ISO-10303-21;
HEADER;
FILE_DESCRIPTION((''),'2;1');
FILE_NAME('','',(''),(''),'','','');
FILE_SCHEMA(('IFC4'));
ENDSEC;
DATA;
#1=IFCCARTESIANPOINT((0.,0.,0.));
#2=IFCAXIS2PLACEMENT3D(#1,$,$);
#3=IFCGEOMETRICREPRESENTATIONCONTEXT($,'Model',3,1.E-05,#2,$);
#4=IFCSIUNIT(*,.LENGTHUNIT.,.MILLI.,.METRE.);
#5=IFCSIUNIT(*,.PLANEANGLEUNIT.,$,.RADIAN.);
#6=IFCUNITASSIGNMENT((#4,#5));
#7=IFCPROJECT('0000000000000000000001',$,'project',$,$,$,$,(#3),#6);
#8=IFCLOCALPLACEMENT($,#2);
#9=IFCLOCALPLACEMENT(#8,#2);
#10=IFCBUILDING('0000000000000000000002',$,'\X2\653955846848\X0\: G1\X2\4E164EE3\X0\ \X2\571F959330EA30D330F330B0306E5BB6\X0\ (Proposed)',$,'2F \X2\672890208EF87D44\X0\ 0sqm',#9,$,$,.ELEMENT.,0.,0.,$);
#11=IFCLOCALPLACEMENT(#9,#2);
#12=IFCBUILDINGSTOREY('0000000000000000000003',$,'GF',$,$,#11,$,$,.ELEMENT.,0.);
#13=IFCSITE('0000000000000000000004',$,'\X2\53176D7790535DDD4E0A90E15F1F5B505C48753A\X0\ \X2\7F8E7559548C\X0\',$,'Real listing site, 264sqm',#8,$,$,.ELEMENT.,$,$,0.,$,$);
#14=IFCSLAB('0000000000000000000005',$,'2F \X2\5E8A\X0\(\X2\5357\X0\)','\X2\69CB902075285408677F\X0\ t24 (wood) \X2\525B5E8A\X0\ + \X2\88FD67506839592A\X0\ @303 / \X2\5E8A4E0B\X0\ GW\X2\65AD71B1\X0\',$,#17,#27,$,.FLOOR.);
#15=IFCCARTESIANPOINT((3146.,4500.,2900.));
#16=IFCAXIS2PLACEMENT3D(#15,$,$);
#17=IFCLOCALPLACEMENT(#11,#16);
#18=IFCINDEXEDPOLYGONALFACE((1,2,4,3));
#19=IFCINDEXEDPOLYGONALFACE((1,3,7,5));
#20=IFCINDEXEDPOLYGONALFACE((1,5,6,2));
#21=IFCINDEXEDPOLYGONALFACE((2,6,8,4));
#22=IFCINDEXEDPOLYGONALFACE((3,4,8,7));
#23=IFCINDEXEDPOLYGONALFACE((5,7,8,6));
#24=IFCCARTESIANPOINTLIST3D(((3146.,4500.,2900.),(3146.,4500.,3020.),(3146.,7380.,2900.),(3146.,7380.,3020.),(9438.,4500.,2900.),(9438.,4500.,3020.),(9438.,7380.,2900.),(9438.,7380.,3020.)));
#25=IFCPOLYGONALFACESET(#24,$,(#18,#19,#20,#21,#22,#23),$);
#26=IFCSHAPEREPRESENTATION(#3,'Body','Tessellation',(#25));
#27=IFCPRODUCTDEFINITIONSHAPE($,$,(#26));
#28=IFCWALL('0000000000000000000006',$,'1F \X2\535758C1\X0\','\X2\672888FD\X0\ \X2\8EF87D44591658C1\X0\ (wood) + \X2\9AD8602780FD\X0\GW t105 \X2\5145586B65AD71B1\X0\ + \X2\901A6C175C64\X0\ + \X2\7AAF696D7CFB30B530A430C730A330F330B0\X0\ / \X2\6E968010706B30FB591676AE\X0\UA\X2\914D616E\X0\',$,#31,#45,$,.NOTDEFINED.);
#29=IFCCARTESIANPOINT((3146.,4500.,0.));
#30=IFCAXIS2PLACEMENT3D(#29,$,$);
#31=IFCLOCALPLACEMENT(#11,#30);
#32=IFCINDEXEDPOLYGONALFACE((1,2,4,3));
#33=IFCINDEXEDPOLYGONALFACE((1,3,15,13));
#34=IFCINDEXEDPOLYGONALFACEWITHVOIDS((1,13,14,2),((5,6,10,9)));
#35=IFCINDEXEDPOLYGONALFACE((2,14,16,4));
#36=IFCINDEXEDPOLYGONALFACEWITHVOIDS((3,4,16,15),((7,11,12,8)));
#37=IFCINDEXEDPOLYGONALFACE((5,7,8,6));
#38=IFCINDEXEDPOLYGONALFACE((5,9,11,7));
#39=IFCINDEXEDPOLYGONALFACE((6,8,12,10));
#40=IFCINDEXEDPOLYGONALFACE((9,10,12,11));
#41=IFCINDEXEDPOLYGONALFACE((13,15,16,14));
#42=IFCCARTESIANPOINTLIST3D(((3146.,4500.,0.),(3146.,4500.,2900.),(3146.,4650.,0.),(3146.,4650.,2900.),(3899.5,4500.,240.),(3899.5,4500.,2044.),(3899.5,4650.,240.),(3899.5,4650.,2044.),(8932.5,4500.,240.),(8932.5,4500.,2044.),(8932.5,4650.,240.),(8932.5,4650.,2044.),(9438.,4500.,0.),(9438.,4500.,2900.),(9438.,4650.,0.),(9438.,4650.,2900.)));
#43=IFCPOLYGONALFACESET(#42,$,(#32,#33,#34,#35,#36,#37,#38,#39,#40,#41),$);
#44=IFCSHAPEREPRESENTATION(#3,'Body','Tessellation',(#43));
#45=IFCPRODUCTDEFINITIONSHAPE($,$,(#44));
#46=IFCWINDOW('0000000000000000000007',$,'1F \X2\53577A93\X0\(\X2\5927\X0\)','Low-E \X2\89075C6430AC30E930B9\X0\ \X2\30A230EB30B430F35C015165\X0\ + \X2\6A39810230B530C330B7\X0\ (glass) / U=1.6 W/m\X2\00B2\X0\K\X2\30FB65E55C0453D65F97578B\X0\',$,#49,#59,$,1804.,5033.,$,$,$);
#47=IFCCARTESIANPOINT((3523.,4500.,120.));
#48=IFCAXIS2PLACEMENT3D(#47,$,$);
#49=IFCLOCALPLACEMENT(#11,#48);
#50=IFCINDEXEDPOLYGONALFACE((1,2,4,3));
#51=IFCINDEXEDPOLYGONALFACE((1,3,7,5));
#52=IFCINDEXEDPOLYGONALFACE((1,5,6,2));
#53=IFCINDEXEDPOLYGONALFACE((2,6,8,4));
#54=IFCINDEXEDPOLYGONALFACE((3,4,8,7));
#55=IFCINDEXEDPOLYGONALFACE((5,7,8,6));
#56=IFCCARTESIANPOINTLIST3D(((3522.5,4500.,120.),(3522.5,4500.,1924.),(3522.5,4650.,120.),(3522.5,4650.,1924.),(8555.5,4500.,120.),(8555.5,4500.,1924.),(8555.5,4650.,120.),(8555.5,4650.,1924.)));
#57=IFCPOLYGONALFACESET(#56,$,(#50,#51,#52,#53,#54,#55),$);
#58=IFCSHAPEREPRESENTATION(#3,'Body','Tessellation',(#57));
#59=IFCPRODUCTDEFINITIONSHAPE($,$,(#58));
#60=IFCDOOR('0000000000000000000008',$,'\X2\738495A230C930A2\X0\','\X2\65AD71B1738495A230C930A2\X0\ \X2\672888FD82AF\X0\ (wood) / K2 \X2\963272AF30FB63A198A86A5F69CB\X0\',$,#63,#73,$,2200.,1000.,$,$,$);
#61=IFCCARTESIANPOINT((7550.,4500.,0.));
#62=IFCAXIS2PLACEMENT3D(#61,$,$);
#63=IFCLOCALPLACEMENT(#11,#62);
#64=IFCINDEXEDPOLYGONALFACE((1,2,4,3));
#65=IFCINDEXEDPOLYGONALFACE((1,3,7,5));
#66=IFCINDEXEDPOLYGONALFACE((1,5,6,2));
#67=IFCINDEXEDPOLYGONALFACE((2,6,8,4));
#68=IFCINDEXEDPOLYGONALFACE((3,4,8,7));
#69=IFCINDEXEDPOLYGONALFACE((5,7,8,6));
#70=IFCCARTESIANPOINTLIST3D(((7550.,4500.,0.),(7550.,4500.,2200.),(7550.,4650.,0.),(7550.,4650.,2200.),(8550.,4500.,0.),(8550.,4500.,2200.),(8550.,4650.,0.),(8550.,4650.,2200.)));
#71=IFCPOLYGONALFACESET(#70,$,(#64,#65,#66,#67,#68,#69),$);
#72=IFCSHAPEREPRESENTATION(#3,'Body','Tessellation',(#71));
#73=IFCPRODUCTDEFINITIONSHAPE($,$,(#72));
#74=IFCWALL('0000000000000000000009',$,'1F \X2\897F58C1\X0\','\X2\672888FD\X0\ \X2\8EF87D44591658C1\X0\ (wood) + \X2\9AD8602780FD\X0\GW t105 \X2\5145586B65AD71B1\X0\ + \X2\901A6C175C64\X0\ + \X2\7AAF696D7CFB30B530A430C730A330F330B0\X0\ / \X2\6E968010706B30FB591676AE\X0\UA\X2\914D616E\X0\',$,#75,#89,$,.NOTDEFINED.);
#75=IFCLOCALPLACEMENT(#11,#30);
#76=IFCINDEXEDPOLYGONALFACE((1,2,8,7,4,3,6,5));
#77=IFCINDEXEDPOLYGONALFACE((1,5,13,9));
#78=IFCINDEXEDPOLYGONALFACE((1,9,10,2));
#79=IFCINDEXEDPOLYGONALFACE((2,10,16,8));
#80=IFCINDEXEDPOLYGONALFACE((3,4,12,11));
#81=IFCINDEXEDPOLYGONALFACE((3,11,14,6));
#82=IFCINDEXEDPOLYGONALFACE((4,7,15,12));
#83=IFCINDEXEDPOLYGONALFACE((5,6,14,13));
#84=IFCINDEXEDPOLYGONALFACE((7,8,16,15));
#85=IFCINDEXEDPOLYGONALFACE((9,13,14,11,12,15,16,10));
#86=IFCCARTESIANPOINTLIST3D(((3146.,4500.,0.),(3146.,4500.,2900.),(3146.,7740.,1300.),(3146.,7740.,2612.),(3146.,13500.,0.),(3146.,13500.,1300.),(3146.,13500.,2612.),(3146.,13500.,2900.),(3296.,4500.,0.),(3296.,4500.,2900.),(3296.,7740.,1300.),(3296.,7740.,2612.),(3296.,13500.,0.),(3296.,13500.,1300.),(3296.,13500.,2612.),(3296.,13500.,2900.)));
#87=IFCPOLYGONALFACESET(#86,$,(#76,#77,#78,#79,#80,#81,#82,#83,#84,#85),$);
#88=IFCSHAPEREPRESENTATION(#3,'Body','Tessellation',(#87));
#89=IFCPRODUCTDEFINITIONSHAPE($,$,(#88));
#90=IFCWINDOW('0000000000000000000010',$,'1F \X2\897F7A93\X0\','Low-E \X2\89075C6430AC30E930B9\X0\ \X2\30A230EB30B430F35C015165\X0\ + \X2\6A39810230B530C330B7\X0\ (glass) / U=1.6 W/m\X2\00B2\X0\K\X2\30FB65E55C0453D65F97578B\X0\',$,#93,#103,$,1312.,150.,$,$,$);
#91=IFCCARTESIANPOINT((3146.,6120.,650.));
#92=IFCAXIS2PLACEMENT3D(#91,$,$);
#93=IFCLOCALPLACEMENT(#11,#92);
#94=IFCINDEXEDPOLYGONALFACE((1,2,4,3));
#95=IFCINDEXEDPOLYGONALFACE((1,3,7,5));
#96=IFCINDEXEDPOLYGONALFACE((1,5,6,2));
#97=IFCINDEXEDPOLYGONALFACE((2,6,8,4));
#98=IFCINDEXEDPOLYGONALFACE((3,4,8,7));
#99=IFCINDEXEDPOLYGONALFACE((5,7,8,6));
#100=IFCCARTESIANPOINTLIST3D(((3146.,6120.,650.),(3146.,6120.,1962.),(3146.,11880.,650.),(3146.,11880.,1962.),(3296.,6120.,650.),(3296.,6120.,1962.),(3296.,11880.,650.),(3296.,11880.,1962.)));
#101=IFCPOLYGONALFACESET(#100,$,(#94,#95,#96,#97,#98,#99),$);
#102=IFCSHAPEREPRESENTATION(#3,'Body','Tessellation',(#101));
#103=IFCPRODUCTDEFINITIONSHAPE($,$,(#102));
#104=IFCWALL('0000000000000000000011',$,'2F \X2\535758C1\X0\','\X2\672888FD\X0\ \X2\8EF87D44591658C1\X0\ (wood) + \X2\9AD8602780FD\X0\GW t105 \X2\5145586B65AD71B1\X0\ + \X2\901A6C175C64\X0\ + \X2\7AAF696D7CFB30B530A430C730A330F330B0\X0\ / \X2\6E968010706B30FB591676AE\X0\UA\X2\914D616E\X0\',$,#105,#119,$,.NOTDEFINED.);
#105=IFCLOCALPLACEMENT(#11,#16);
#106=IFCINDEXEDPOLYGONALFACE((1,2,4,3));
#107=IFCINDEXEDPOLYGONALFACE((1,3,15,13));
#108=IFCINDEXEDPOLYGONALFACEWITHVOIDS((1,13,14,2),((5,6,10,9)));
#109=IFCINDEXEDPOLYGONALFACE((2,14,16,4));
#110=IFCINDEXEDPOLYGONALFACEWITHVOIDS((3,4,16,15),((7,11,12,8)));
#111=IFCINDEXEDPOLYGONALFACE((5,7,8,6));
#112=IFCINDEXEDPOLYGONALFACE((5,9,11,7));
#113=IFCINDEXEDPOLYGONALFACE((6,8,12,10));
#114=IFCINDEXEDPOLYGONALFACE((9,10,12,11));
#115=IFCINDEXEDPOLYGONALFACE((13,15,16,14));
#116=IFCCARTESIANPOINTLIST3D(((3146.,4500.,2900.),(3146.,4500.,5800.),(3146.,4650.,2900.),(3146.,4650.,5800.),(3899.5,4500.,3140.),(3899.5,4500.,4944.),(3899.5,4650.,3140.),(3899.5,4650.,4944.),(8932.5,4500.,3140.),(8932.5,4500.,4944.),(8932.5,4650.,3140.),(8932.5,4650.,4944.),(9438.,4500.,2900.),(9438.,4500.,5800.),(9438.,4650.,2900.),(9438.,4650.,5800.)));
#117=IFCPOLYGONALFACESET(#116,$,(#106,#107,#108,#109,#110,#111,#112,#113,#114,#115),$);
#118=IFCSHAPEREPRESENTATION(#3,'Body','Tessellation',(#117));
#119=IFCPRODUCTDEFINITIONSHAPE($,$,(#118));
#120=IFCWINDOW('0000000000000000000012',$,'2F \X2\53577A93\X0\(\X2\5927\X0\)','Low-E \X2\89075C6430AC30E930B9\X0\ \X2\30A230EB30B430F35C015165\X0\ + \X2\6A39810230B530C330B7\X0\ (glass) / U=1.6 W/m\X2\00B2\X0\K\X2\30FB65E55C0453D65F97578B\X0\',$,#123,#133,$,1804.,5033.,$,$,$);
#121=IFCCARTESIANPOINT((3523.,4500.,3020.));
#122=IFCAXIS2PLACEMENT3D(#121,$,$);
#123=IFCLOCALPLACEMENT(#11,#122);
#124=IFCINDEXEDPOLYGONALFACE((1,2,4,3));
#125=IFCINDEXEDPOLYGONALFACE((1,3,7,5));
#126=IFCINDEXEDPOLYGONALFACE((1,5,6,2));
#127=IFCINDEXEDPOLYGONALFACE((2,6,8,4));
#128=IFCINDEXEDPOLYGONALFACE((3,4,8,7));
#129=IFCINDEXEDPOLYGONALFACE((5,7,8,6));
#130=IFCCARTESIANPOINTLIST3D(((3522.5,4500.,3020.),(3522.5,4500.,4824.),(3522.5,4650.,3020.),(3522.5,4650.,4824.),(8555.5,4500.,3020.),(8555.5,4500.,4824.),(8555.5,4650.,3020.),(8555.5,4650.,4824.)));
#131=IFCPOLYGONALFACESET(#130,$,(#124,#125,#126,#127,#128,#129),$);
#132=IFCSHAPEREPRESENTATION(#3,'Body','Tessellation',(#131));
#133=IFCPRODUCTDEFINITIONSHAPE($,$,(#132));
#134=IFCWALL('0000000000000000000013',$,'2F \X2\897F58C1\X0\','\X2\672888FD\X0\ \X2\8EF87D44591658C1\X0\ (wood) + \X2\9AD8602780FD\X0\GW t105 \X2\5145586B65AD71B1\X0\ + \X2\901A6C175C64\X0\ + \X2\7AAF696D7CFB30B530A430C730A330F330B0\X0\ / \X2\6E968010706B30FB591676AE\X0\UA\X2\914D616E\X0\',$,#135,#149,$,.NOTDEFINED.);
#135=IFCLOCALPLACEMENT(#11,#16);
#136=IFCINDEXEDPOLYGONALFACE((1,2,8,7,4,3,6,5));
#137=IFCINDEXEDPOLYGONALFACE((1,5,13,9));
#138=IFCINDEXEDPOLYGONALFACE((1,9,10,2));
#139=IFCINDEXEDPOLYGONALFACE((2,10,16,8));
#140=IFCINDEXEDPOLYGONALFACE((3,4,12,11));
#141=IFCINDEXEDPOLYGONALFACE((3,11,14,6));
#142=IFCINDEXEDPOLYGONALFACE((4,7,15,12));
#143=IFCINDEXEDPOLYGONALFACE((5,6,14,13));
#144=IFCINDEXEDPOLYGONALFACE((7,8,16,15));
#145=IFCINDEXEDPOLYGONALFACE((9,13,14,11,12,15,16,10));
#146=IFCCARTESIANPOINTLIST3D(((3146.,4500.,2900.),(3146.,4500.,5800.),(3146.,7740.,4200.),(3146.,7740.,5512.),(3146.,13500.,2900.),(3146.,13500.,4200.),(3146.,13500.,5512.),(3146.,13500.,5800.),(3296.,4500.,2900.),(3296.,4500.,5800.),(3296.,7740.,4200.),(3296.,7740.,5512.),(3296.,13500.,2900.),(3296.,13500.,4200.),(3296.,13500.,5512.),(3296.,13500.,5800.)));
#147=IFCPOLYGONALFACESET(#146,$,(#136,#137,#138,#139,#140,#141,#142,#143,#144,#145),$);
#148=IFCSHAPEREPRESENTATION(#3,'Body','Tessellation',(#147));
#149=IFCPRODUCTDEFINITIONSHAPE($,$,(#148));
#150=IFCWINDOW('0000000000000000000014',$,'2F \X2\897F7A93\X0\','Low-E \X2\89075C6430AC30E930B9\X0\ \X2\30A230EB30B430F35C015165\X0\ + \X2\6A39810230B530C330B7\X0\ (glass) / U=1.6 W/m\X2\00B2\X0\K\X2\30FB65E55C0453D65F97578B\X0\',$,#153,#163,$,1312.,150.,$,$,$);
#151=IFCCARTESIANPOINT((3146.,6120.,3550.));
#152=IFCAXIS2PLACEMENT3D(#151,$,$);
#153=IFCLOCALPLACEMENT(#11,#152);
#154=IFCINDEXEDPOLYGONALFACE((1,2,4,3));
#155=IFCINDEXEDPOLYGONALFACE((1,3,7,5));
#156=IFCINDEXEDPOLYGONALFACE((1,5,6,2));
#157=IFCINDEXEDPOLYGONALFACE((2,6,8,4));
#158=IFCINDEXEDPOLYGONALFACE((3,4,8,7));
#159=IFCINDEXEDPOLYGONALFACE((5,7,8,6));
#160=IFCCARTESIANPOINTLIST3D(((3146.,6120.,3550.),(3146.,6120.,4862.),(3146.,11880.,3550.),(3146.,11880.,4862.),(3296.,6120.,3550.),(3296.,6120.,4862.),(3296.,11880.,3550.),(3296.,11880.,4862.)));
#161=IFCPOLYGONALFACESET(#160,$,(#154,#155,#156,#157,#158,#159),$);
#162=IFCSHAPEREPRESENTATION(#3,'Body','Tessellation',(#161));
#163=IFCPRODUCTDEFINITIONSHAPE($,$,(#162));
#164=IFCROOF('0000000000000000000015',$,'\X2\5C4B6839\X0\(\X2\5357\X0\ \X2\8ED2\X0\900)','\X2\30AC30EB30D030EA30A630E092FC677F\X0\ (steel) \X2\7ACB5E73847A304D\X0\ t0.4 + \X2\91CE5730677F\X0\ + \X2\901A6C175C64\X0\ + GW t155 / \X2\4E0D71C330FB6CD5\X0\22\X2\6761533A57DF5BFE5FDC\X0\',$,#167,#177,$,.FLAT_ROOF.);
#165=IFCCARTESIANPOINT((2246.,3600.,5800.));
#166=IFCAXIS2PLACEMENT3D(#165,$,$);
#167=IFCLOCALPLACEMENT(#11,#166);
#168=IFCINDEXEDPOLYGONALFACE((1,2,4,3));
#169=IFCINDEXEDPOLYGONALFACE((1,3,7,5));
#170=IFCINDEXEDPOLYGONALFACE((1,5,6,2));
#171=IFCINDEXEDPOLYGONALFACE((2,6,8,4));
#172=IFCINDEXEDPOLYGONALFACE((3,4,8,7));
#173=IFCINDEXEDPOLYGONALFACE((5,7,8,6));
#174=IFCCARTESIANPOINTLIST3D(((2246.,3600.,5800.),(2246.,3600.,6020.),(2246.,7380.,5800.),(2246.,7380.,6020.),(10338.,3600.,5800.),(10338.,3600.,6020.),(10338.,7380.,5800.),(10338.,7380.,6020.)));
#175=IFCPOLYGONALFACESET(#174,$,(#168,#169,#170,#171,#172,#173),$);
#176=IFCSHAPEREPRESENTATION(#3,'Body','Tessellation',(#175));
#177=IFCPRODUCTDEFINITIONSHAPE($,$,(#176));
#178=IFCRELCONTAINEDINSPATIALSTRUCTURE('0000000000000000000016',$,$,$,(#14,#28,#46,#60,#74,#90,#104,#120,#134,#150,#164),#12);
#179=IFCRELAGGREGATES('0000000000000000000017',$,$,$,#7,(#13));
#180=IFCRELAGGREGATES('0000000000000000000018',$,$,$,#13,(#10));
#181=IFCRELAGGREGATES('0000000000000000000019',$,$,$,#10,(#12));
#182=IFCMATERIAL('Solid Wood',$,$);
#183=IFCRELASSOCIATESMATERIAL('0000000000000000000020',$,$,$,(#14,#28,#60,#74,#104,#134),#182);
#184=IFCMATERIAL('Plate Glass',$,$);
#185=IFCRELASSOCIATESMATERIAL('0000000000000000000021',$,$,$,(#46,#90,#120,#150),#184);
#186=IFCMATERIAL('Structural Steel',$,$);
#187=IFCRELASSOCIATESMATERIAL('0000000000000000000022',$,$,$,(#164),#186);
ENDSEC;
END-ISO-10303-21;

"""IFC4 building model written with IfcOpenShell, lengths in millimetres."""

from ifc_helpers import new_model, si_unit, frame, frame_2d, origin, place, context, project, spatial, rectangle, extrude, material, element, fill, save


model = new_model("IFC4")

# Units and contexts
model_context = context("Model", 3, precision=1e-05, world=origin())
ifc_project = project(units=[si_unit("LENGTHUNIT", "METRE", prefix="MILLI"), si_unit("PLANEANGLEUNIT", "RADIAN")], contexts=[model_context])

# Site, building, storey
site_placement = place(None, origin())
site = spatial("IfcSite", under=ifc_project, at=site_placement, Name="北海道川上郡弟子屈町 美留和", ObjectType="Real listing site, 264sqm", CompositionType="ELEMENT", RefElevation=0.0)
building_placement = place(site_placement, origin())
building = spatial("IfcBuilding", under=site, at=building_placement, Name="改善案: G1世代 土間リビングの家 (Proposed)", ObjectType="2F 木造軸組 0sqm", CompositionType="ELEMENT", ElevationOfRefHeight=0.0, ElevationOfTerrain=0.0)
storey_placement = place(building_placement, origin())
storey = spatial("IfcBuildingStorey", under=building, at=storey_placement, Name="GF", CompositionType="ELEMENT", Elevation=0.0)

# Slab
ifc_material_1 = material(Name="Solid Wood")
slab_1_placement = place(storey_placement, frame((3146.0, 4500.0, 2900.0)))
element("IfcSlab", 1, at=slab_1_placement, inside=storey, material=ifc_material_1, Name="2F 床(南)", Description="構造用合板 t24 (wood) 剛床 + 製材根太 @303 / 床下 GW断熱", PredefinedType="FLOOR", context=model_context, shape_type="SweptSolid", body=[
    extrude(rectangle(XDim=6292.0, YDim=2880.0, at=frame_2d((3146.0, 1440.0))), frame((3146.0, 4500.0, 2900.0)), (0.0, 0.0, 1.0), 120.0),
])

# Wall, openings, window, door
wall_1_placement = place(storey_placement, frame((3146.0, 4500.0, 0.0)))
wall_1 = element("IfcWall", 2, at=wall_1_placement, inside=storey, material=ifc_material_1, Name="1F 南壁", Description="木製 軸組外壁 (wood) + 高性能GW t105 充填断熱 + 通気層 + 窯業系サイディング / 準耐火・外皮UA配慮", PredefinedType="NOTDEFINED", context=model_context, shape_type="SweptSolid", body=[
    extrude(rectangle(XDim=6292.0, YDim=150.0, at=frame_2d((3146.0, 75.0))), frame((3146.0, 4500.0, 0.0)), (0.0, 0.0, 1.0), 2900.0),
])
opening_1_placement = place(storey_placement, frame((3523.0, 4500.0, 120.0)))
opening_1 = element("IfcOpeningElement", 3, at=opening_1_placement, cuts=wall_1, PredefinedType="NOTDEFINED", context=model_context, shape_type="SweptSolid", body=[
    extrude(rectangle(XDim=5033.0, YDim=150.0, at=frame_2d((2516.0, 75.0))), frame((3523.0, 4500.0, 120.0)), (0.0, 0.0, 1.0), 1804.0),
])
opening_2_placement = place(storey_placement, frame((7550.0, 4500.0, 0.0)))
opening_2 = element("IfcOpeningElement", 4, at=opening_2_placement, cuts=wall_1, PredefinedType="NOTDEFINED", context=model_context, shape_type="SweptSolid", body=[
    extrude(rectangle(XDim=1000.0, YDim=150.0, at=frame_2d((500.0, 75.0))), frame((7550.0, 4500.0, 0.0)), (0.0, 0.0, 1.0), 2200.0),
])
ifc_material_2 = material(Name="Plate Glass")
window_1_placement = place(storey_placement, frame((3523.0, 4500.0, 120.0)))
window_1 = element("IfcWindow", 5, at=window_1_placement, inside=storey, material=ifc_material_2, Name="1F 南窓(大)", Description="Low-E 複層ガラス アルゴン封入 + 樹脂サッシ (glass) / U=1.6 W/m²K・日射取得型", OverallHeight=1804.0, OverallWidth=5033.0, context=model_context, shape_type="SweptSolid", body=[
    extrude(rectangle(XDim=5033.0, YDim=150.0, at=frame_2d((2516.0, 75.0))), frame((3523.0, 4500.0, 120.0)), (0.0, 0.0, 1.0), 1804.0),
])
fill(opening_1, window_1)
door_placement = place(storey_placement, frame((7550.0, 4500.0, 0.0)))
door = element("IfcDoor", 6, at=door_placement, inside=storey, material=ifc_material_1, Name="玄関ドア", Description="断熱玄関ドア 木製芯 (wood) / K2 防犯・採風機構", OverallHeight=2200.0, OverallWidth=1000.0, context=model_context, shape_type="SweptSolid", body=[
    extrude(rectangle(XDim=1000.0, YDim=150.0, at=frame_2d((500.0, 75.0))), frame((7550.0, 4500.0, 0.0)), (0.0, 0.0, 1.0), 2200.0),
])
fill(opening_2, door)

# Walls, openings, windows
wall_2_placement = place(storey_placement, frame((3146.0, 4500.0, 0.0)))
wall_2 = element("IfcWall", 7, at=wall_2_placement, inside=storey, material=ifc_material_1, Name="1F 西壁", Description="木製 軸組外壁 (wood) + 高性能GW t105 充填断熱 + 通気層 + 窯業系サイディング / 準耐火・外皮UA配慮", PredefinedType="NOTDEFINED", context=model_context, shape_type="SweptSolid", body=[
    extrude(rectangle(XDim=150.0, YDim=9000.0, at=frame_2d((75.0, 4500.0))), frame((3146.0, 4500.0, 0.0)), (0.0, 0.0, 1.0), 2900.0),
])
opening_3_placement = place(storey_placement, frame((3146.0, 6120.0, 650.0)))
opening_3 = element("IfcOpeningElement", 8, at=opening_3_placement, cuts=wall_2, PredefinedType="NOTDEFINED", context=model_context, shape_type="SweptSolid", body=[
    extrude(rectangle(XDim=150.0, YDim=5760.0, at=frame_2d((75.0, 2880.0))), frame((3146.0, 6120.0, 650.0)), (0.0, 0.0, 1.0), 1312.0),
])
window_2_placement = place(storey_placement, frame((3146.0, 6120.0, 650.0)))
window_2 = element("IfcWindow", 9, at=window_2_placement, inside=storey, material=ifc_material_2, Name="1F 西窓", Description="Low-E 複層ガラス アルゴン封入 + 樹脂サッシ (glass) / U=1.6 W/m²K・日射取得型", OverallHeight=1312.0, OverallWidth=150.0, context=model_context, shape_type="SweptSolid", body=[
    extrude(rectangle(XDim=150.0, YDim=5760.0, at=frame_2d((75.0, 2880.0))), frame((3146.0, 6120.0, 650.0)), (0.0, 0.0, 1.0), 1312.0),
])
fill(opening_3, window_2)
wall_3_placement = place(storey_placement, frame((3146.0, 4500.0, 2900.0)))
wall_3 = element("IfcWall", 10, at=wall_3_placement, inside=storey, material=ifc_material_1, Name="2F 南壁", Description="木製 軸組外壁 (wood) + 高性能GW t105 充填断熱 + 通気層 + 窯業系サイディング / 準耐火・外皮UA配慮", PredefinedType="NOTDEFINED", context=model_context, shape_type="SweptSolid", body=[
    extrude(rectangle(XDim=6292.0, YDim=150.0, at=frame_2d((3146.0, 75.0))), frame((3146.0, 4500.0, 2900.0)), (0.0, 0.0, 1.0), 2900.0),
])
opening_4_placement = place(storey_placement, frame((3523.0, 4500.0, 3020.0)))
opening_4 = element("IfcOpeningElement", 11, at=opening_4_placement, cuts=wall_3, PredefinedType="NOTDEFINED", context=model_context, shape_type="SweptSolid", body=[
    extrude(rectangle(XDim=5033.0, YDim=150.0, at=frame_2d((2516.0, 75.0))), frame((3523.0, 4500.0, 3020.0)), (0.0, 0.0, 1.0), 1804.0),
])
window_3_placement = place(storey_placement, frame((3523.0, 4500.0, 3020.0)))
window_3 = element("IfcWindow", 12, at=window_3_placement, inside=storey, material=ifc_material_2, Name="2F 南窓(大)", Description="Low-E 複層ガラス アルゴン封入 + 樹脂サッシ (glass) / U=1.6 W/m²K・日射取得型", OverallHeight=1804.0, OverallWidth=5033.0, context=model_context, shape_type="SweptSolid", body=[
    extrude(rectangle(XDim=5033.0, YDim=150.0, at=frame_2d((2516.0, 75.0))), frame((3523.0, 4500.0, 3020.0)), (0.0, 0.0, 1.0), 1804.0),
])
fill(opening_4, window_3)
wall_4_placement = place(storey_placement, frame((3146.0, 4500.0, 2900.0)))
wall_4 = element("IfcWall", 13, at=wall_4_placement, inside=storey, material=ifc_material_1, Name="2F 西壁", Description="木製 軸組外壁 (wood) + 高性能GW t105 充填断熱 + 通気層 + 窯業系サイディング / 準耐火・外皮UA配慮", PredefinedType="NOTDEFINED", context=model_context, shape_type="SweptSolid", body=[
    extrude(rectangle(XDim=150.0, YDim=9000.0, at=frame_2d((75.0, 4500.0))), frame((3146.0, 4500.0, 2900.0)), (0.0, 0.0, 1.0), 2900.0),
])
opening_5_placement = place(storey_placement, frame((3146.0, 6120.0, 3550.0)))
opening_5 = element("IfcOpeningElement", 14, at=opening_5_placement, cuts=wall_4, PredefinedType="NOTDEFINED", context=model_context, shape_type="SweptSolid", body=[
    extrude(rectangle(XDim=150.0, YDim=5760.0, at=frame_2d((75.0, 2880.0))), frame((3146.0, 6120.0, 3550.0)), (0.0, 0.0, 1.0), 1312.0),
])
window_4_placement = place(storey_placement, frame((3146.0, 6120.0, 3550.0)))
window_4 = element("IfcWindow", 15, at=window_4_placement, inside=storey, material=ifc_material_2, Name="2F 西窓", Description="Low-E 複層ガラス アルゴン封入 + 樹脂サッシ (glass) / U=1.6 W/m²K・日射取得型", OverallHeight=1312.0, OverallWidth=150.0, context=model_context, shape_type="SweptSolid", body=[
    extrude(rectangle(XDim=150.0, YDim=5760.0, at=frame_2d((75.0, 2880.0))), frame((3146.0, 6120.0, 3550.0)), (0.0, 0.0, 1.0), 1312.0),
])
fill(opening_5, window_4)

# Roof
ifc_material_3 = material(Name="Structural Steel")
roof_1_placement = place(storey_placement, frame((2246.0, 3600.0, 5800.0)))
element("IfcRoof", 16, at=roof_1_placement, inside=storey, material=ifc_material_3, Name="屋根(南 軒900)", Description="ガルバリウム鋼板 (steel) 立平葺き t0.4 + 野地板 + 通気層 + GW t155 / 不燃・法22条区域対応", PredefinedType="FLAT_ROOF", context=model_context, shape_type="SweptSolid", body=[
    extrude(rectangle(XDim=8092.0, YDim=3780.0, at=frame_2d((4046.0, 1890.0))), frame((2246.0, 3600.0, 5800.0)), (0.0, 0.0, 1.0), 220.0),
])

save(model, "model.ifc")
